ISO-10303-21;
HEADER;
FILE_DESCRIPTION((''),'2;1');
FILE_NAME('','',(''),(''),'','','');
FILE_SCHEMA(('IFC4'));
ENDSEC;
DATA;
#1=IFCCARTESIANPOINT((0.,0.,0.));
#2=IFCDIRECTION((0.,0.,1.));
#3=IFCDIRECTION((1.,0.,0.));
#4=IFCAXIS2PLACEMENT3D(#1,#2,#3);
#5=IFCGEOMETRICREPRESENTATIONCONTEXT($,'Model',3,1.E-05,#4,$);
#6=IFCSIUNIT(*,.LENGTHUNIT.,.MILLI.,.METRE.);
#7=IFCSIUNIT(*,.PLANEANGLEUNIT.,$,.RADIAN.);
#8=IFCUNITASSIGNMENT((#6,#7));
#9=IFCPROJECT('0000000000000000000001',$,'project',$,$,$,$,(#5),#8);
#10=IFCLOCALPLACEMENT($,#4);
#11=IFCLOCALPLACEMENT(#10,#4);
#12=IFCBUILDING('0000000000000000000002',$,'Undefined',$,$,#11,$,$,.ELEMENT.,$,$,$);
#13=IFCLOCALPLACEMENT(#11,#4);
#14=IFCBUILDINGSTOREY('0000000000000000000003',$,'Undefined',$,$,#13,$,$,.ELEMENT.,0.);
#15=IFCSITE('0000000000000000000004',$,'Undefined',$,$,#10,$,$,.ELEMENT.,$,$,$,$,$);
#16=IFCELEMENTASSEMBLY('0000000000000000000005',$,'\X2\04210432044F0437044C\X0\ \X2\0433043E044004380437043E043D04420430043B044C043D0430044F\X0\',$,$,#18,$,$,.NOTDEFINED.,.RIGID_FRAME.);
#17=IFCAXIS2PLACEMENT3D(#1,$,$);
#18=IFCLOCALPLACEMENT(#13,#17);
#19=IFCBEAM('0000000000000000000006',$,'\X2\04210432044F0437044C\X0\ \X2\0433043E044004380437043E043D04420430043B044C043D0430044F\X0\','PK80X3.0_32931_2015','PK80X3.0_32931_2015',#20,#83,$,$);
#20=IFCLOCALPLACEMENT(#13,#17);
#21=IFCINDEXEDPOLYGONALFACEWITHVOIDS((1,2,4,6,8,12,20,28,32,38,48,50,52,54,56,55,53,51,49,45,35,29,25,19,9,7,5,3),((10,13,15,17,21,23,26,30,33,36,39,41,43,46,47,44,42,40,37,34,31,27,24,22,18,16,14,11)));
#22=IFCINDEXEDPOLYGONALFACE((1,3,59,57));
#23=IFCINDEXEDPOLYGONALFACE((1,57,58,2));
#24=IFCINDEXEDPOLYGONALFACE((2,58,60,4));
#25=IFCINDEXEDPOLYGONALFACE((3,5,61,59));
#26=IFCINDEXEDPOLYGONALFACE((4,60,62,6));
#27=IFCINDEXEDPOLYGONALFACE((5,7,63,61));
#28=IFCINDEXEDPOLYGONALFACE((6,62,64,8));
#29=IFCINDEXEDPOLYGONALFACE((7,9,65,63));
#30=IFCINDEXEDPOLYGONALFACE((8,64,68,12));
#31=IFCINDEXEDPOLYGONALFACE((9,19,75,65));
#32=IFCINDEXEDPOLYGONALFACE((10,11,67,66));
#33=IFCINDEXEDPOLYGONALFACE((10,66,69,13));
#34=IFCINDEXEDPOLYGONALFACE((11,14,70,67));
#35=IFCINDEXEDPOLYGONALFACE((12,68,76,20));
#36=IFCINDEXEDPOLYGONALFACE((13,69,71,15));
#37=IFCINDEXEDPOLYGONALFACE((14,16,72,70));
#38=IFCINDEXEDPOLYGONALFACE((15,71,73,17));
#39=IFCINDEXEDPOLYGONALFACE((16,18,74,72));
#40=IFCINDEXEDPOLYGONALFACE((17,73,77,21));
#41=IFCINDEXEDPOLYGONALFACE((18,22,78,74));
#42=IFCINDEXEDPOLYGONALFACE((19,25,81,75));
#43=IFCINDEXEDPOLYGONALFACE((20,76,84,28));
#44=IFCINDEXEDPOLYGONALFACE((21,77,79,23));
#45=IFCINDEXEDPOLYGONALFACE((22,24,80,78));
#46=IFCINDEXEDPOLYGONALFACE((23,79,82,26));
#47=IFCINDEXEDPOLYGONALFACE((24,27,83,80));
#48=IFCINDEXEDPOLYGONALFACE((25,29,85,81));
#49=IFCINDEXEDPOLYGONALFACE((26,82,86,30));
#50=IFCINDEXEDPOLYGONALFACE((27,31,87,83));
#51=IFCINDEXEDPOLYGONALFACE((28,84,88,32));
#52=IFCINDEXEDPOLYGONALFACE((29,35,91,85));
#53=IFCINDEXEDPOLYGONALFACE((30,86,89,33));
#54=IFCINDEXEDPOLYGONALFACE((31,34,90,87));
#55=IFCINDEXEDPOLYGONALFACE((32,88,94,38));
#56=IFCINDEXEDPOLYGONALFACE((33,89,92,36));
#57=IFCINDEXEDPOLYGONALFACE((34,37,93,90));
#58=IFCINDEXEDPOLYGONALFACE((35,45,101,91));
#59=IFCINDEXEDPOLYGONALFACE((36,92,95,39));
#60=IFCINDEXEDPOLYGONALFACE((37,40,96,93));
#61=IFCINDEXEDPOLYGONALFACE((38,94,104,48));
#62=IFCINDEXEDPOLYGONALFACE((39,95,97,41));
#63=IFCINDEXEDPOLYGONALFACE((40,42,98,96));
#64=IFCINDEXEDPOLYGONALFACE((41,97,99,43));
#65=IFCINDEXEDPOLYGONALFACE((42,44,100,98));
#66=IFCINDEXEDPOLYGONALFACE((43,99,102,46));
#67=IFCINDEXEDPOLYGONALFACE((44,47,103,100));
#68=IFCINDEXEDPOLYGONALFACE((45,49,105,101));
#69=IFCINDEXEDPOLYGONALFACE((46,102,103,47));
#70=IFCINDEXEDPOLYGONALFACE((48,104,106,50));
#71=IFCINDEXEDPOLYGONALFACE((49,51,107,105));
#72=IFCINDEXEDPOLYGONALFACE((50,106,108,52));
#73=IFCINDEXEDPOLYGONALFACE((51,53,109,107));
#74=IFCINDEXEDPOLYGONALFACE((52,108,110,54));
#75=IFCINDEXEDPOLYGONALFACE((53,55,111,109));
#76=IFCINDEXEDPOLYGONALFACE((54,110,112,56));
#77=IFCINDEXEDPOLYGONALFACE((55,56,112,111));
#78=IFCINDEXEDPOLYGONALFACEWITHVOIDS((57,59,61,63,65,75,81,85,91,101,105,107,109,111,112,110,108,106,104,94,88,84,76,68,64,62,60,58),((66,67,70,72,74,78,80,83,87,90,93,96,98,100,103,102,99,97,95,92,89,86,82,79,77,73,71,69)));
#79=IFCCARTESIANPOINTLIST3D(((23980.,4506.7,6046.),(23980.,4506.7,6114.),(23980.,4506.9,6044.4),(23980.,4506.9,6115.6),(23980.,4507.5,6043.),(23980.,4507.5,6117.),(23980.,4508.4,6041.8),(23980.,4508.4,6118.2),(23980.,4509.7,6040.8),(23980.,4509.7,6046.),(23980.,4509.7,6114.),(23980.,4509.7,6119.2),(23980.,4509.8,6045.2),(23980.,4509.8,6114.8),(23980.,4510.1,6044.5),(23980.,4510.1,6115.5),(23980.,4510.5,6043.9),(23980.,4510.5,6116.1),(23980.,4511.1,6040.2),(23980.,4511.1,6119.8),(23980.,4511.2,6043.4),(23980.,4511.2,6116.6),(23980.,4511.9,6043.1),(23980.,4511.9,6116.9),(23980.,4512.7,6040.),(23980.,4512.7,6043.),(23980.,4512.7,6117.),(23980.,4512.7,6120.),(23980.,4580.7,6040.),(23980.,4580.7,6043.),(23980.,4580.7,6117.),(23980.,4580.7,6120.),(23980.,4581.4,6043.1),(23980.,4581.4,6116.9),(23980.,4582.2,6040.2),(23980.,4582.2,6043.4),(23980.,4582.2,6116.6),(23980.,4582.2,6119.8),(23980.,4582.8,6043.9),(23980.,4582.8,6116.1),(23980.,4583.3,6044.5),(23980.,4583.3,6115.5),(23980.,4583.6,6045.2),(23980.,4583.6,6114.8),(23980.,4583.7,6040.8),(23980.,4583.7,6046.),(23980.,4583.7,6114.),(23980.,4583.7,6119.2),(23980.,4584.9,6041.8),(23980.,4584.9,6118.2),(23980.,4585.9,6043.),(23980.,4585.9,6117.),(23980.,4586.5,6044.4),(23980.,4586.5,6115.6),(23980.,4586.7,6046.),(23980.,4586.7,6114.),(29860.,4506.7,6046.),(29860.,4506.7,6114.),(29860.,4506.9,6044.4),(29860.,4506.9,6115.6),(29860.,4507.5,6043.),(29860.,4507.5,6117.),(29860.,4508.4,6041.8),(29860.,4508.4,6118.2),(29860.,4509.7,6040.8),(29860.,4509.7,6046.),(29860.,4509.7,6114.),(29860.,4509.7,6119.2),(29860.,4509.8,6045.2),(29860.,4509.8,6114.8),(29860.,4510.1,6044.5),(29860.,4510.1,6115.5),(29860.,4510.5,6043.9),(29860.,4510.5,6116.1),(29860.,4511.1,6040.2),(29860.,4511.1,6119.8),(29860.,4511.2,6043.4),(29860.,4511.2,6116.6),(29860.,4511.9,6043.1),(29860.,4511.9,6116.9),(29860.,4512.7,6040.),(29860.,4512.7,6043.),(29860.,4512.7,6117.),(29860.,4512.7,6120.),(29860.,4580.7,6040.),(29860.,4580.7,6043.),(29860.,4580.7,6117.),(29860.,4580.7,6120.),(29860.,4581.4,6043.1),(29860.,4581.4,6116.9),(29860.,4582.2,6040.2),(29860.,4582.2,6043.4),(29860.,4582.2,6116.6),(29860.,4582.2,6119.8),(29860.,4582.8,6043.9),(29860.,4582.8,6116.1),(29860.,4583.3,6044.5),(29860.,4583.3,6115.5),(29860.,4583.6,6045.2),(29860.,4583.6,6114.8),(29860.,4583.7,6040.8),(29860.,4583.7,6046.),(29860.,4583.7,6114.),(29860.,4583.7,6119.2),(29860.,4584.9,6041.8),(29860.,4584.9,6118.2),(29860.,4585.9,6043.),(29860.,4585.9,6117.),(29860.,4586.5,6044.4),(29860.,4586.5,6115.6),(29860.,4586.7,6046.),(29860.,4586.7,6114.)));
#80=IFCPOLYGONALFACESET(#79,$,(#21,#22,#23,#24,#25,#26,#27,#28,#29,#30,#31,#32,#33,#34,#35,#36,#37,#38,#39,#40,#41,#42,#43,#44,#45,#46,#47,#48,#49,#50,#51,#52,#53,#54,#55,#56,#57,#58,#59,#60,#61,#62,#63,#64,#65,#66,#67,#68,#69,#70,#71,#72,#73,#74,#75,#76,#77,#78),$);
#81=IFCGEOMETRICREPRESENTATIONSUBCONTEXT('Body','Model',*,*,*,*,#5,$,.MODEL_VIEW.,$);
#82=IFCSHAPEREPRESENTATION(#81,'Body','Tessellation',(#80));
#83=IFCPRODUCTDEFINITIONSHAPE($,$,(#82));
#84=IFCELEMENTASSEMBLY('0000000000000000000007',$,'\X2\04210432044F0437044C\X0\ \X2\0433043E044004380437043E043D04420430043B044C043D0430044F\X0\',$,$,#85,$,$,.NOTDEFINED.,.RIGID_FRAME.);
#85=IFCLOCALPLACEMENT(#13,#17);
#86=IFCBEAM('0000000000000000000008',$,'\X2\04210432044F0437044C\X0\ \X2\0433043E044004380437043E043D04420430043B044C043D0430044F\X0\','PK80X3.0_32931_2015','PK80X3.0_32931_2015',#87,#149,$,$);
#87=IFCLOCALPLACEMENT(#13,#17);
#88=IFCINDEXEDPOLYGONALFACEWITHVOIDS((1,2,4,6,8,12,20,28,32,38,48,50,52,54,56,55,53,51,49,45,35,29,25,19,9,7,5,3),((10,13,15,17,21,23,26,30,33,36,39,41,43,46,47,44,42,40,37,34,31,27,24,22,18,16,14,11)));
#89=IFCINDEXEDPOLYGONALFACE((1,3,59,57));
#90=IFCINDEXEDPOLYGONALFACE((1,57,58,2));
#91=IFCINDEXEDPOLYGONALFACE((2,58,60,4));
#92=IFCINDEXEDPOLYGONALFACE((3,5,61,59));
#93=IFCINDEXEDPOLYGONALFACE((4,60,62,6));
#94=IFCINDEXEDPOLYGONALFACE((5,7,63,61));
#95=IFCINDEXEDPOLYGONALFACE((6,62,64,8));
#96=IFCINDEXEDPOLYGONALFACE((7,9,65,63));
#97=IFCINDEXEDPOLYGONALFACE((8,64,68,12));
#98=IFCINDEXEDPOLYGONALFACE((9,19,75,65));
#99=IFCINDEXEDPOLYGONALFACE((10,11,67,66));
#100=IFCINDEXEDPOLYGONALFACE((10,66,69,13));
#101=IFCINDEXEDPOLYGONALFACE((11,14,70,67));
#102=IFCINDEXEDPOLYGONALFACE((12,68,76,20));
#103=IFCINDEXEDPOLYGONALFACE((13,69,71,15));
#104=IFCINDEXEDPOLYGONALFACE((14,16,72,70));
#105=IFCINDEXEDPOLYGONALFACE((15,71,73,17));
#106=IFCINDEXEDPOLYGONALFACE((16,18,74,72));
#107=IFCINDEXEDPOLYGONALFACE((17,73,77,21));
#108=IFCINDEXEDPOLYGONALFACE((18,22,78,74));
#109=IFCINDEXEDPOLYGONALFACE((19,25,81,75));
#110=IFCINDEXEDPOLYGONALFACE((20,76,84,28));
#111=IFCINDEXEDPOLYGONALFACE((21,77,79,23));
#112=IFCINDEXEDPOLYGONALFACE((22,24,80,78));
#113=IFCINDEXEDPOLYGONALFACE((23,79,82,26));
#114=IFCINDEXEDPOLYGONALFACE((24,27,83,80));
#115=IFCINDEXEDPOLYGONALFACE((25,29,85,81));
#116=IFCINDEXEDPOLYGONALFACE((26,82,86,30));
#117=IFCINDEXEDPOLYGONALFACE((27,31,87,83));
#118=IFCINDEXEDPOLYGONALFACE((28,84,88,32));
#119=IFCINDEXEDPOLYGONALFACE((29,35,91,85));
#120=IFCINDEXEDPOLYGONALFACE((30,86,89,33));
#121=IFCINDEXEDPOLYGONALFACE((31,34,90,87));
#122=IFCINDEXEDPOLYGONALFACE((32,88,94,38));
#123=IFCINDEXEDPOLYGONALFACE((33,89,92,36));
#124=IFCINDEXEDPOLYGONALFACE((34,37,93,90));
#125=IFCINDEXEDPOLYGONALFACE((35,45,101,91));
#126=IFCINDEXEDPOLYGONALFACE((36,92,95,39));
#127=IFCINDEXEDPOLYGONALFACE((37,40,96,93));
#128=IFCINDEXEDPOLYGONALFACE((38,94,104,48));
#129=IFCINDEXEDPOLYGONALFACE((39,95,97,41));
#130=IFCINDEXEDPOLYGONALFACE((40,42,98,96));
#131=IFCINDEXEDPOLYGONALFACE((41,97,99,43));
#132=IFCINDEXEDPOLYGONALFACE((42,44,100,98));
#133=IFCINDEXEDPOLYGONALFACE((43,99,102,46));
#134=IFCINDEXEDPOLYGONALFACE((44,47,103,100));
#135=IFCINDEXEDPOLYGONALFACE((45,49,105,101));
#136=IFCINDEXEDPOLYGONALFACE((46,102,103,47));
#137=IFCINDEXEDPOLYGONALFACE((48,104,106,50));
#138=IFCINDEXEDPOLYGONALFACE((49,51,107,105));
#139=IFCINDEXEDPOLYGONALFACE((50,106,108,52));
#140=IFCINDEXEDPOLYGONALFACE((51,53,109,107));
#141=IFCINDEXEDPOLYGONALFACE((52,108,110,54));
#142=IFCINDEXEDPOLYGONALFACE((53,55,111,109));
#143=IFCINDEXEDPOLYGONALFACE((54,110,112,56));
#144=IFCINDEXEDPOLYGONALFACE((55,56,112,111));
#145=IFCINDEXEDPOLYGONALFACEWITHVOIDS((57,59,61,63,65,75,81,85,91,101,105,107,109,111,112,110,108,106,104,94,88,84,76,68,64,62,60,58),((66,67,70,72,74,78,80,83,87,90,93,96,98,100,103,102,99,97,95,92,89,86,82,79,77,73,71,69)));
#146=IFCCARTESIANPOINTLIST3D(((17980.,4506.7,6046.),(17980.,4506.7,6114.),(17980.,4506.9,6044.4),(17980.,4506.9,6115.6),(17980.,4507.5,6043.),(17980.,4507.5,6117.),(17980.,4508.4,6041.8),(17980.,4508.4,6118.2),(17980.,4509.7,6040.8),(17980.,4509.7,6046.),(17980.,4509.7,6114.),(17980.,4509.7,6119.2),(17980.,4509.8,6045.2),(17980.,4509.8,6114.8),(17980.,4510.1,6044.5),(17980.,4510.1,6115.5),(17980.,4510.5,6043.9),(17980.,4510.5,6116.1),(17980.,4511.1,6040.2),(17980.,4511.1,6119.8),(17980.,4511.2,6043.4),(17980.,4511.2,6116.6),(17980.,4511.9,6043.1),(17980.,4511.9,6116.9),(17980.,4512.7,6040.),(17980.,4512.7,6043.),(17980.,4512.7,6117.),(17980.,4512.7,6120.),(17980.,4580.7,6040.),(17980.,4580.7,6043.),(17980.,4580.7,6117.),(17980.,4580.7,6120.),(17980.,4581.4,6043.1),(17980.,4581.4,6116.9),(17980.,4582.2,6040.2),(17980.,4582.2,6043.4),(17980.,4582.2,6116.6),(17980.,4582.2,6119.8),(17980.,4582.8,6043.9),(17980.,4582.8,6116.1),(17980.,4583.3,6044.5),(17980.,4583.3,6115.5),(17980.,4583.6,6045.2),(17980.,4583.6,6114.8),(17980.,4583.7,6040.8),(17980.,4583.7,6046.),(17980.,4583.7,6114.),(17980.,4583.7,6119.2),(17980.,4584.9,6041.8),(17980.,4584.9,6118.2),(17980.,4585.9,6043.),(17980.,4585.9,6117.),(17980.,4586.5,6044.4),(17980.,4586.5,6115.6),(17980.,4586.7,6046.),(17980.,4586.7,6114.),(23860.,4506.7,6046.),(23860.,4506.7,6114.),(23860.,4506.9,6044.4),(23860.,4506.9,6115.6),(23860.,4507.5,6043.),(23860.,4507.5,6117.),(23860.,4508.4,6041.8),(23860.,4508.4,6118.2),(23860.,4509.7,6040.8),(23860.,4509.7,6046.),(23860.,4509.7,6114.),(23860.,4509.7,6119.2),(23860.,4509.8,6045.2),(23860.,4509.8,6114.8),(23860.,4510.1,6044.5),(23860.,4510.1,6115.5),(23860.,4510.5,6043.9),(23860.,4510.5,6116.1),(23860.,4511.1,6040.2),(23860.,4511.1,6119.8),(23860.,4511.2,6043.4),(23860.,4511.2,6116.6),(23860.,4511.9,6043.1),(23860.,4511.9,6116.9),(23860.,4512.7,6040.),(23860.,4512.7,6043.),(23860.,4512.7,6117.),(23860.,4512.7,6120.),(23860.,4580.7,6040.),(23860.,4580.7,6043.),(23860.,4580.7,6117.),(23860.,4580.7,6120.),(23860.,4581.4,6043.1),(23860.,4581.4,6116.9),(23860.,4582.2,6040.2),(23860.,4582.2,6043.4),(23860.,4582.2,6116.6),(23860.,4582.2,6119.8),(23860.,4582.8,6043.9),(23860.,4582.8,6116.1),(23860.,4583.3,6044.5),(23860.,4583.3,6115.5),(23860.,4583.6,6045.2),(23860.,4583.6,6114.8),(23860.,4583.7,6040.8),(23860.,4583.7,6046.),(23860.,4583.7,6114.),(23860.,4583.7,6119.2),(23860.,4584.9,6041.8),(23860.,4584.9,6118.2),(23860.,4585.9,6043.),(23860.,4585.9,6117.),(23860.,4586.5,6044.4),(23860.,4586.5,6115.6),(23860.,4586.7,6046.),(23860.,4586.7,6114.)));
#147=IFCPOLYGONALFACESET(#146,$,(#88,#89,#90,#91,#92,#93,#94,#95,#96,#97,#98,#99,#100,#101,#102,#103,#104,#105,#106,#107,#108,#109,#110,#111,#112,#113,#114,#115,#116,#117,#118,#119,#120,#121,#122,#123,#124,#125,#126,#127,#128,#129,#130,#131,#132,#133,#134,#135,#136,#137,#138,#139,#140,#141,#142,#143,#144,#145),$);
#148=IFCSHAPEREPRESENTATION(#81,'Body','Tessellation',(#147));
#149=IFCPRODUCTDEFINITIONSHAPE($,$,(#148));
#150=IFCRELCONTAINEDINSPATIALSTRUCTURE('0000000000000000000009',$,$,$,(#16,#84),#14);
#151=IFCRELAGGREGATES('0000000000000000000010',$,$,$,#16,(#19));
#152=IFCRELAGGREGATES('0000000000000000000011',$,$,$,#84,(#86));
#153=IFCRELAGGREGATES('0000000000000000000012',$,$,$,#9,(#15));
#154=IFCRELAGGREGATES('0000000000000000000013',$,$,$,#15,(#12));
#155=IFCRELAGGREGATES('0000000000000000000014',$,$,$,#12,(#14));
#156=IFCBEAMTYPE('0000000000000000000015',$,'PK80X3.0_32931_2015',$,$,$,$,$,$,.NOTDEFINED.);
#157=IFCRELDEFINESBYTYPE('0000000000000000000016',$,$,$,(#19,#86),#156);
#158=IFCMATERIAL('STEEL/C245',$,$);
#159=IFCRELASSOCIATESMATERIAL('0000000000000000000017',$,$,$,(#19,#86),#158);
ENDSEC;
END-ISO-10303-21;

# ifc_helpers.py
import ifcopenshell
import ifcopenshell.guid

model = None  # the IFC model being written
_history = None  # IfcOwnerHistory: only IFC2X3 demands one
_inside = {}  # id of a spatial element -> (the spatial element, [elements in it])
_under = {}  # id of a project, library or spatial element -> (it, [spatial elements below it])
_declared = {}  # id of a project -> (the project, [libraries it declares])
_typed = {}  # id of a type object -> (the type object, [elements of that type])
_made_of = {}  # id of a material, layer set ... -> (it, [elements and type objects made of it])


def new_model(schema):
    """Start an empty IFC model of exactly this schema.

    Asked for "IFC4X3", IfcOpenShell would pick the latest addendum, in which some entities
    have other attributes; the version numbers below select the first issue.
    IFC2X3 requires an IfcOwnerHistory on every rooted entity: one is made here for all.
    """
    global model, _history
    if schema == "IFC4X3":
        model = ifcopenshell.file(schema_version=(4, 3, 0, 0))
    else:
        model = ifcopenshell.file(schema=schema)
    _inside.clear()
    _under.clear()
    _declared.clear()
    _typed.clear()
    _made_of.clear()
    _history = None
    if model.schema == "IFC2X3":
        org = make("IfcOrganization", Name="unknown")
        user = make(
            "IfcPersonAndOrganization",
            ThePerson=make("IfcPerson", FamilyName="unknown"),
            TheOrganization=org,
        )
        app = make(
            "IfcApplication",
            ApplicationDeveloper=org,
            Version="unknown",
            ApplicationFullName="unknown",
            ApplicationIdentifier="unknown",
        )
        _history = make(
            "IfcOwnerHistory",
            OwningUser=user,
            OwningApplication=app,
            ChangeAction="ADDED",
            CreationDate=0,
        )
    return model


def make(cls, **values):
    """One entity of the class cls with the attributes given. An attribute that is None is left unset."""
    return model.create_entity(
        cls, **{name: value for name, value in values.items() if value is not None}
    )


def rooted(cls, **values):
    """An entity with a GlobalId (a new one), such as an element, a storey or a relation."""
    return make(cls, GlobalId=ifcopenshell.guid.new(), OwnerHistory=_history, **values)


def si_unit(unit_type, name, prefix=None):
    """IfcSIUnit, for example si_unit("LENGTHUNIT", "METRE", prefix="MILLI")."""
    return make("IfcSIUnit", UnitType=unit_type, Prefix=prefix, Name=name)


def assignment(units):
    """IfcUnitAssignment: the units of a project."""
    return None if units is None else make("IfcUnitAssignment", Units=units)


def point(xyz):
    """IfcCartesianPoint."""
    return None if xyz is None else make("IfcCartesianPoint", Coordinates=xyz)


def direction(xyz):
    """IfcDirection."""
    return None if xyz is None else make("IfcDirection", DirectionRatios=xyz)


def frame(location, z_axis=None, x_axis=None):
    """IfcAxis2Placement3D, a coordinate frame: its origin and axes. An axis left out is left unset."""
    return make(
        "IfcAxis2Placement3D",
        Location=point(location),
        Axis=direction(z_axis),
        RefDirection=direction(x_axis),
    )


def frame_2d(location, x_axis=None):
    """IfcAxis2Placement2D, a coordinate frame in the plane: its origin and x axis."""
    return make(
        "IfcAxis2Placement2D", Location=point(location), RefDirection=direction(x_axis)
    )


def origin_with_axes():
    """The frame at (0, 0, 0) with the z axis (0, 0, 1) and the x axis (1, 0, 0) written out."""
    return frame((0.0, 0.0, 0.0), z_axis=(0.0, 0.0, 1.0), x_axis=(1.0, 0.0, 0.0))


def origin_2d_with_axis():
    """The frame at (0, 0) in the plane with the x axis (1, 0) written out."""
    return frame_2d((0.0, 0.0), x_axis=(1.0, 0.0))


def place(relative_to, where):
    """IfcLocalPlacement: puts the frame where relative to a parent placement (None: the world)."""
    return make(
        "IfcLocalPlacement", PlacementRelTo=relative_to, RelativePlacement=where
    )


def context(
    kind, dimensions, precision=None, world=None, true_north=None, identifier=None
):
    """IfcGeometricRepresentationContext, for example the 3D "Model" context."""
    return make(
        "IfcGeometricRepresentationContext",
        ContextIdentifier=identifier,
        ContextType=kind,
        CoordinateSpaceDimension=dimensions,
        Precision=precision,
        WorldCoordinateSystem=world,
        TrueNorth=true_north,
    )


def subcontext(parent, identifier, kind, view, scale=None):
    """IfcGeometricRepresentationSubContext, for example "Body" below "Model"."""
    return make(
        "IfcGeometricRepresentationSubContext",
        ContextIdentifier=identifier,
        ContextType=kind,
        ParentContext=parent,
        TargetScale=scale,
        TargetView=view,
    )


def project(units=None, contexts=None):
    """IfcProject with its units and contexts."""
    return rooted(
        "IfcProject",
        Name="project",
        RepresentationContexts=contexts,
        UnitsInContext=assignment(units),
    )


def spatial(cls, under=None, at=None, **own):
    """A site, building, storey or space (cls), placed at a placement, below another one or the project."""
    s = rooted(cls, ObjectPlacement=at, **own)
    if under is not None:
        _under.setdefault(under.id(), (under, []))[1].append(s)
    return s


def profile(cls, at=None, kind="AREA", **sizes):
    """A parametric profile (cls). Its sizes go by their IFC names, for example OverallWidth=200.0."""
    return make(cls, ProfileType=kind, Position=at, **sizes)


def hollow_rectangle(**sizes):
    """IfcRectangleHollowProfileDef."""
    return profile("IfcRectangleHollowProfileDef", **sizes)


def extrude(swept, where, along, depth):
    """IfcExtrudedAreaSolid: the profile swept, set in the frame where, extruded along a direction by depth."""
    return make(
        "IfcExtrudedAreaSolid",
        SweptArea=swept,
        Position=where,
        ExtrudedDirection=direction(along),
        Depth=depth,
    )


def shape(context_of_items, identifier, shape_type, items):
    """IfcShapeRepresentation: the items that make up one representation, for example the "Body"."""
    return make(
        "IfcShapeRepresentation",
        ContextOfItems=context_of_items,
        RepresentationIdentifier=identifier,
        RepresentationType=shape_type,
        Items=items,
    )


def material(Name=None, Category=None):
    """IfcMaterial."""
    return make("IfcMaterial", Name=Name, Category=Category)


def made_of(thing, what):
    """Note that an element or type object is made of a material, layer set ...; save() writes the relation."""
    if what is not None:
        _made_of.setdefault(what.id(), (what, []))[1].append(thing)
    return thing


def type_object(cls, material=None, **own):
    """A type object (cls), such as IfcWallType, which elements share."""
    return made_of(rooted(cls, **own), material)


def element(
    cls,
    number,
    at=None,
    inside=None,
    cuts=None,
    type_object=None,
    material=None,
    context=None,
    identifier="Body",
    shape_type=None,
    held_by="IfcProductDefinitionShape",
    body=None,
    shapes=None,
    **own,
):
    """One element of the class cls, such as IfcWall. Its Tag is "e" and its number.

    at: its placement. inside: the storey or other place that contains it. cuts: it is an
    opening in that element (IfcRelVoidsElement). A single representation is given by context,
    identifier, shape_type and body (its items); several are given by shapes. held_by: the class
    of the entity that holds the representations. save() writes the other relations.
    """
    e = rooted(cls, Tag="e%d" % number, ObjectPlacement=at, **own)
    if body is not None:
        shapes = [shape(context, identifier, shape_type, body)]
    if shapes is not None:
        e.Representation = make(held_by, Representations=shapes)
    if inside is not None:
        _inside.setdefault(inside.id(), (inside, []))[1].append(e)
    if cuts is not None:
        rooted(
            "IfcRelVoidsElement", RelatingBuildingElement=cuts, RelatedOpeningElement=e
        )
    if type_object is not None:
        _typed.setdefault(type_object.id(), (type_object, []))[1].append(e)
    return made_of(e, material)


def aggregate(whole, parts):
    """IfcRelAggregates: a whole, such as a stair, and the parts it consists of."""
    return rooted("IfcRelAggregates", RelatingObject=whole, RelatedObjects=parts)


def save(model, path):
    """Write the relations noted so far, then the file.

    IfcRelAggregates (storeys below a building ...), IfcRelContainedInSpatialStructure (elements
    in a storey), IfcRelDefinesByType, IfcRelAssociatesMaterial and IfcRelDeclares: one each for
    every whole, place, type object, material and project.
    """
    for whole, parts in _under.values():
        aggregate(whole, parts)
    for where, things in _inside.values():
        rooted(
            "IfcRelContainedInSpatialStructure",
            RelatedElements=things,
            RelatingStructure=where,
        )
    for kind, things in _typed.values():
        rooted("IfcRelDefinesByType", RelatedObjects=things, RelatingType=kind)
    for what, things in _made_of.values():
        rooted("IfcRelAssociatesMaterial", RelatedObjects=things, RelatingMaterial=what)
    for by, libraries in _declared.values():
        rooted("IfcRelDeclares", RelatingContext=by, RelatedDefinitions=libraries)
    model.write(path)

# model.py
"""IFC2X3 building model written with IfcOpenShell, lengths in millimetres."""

from ifc_helpers import new_model, si_unit, frame, origin_with_axes, origin_2d_with_axis, place, context, subcontext, project, spatial, hollow_rectangle, extrude, material, type_object, element, aggregate, save


model = new_model("IFC2X3")

# Units and contexts
model_context = context("Model", 3, precision=1e-05, world=origin_with_axes())
body_context = subcontext(model_context, "Body", "Model", "MODEL_VIEW")
ifc_project = project(units=[si_unit("LENGTHUNIT", "METRE", prefix="MILLI"), si_unit("PLANEANGLEUNIT", "RADIAN")], contexts=[model_context])

# Site, building, storey
site_placement = place(None, origin_with_axes())
site = spatial("IfcSite", under=ifc_project, at=site_placement, Name="Undefined", CompositionType="ELEMENT")
building_placement = place(site_placement, origin_with_axes())
building = spatial("IfcBuilding", under=site, at=building_placement, Name="Undefined", CompositionType="ELEMENT")
storey_placement = place(building_placement, origin_with_axes())
storey = spatial("IfcBuildingStorey", under=building, at=storey_placement, Name="Undefined", CompositionType="ELEMENT", Elevation=0.0)

# Shared definitions
ifc_material = material(Name="STEEL/C245")

# Element assemblies, beams
assembly_1_placement = place(storey_placement, origin_with_axes())
assembly_1 = element("IfcElementAssembly", 1, at=assembly_1_placement, inside=storey, Name="Связь горизонтальная", AssemblyPlace="NOTDEFINED", PredefinedType="RIGID_FRAME")
beam_type_1 = type_object("IfcBeamType", Name="PK80X3.0_32931_2015", PredefinedType="NOTDEFINED")
beam_1_placement = place(assembly_1_placement, frame((23980.0, 4546.7, 6080.0), z_axis=(0.0, 0.0, 1.0), x_axis=(1.0, 0.0, 0.0)))
beam_1 = element("IfcBeam", 2, at=beam_1_placement, type_object=beam_type_1, material=ifc_material, Name="Связь горизонтальная", Description="PK80X3.0_32931_2015", ObjectType="PK80X3.0_32931_2015", context=body_context, shape_type="SweptSolid", body=[
    extrude(hollow_rectangle(XDim=80.0, YDim=80.0, WallThickness=3.0, InnerFilletRadius=3.0, OuterFilletRadius=6.0, at=origin_2d_with_axis()), frame((5880.0, 0.0, 0.0), z_axis=(-1.0, 0.0, 0.0), x_axis=(0.0, -1.0, 0.0)), (0.0, 0.0, 1.0), 5880.0),
])
aggregate(assembly_1, [beam_1])
assembly_2_placement = place(storey_placement, origin_with_axes())
assembly_2 = element("IfcElementAssembly", 3, at=assembly_2_placement, inside=storey, Name="Связь горизонтальная", AssemblyPlace="NOTDEFINED", PredefinedType="RIGID_FRAME")
beam_2_placement = place(assembly_2_placement, frame((17980.0, 4546.7, 6080.0), z_axis=(0.0, 0.0, 1.0), x_axis=(1.0, 0.0, 0.0)))
beam_2 = element("IfcBeam", 4, at=beam_2_placement, type_object=beam_type_1, material=ifc_material, Name="Связь горизонтальная", Description="PK80X3.0_32931_2015", ObjectType="PK80X3.0_32931_2015", context=body_context, shape_type="SweptSolid", body=[
    extrude(hollow_rectangle(XDim=80.0, YDim=80.0, WallThickness=3.0, InnerFilletRadius=3.0, OuterFilletRadius=6.0, at=origin_2d_with_axis()), frame((5880.0, 0.0, 0.0), z_axis=(-1.0, 0.0, 0.0), x_axis=(0.0, -1.0, 0.0)), (0.0, 0.0, 1.0), 5880.0),
])
aggregate(assembly_2, [beam_2])

save(model, "model.ifc")
